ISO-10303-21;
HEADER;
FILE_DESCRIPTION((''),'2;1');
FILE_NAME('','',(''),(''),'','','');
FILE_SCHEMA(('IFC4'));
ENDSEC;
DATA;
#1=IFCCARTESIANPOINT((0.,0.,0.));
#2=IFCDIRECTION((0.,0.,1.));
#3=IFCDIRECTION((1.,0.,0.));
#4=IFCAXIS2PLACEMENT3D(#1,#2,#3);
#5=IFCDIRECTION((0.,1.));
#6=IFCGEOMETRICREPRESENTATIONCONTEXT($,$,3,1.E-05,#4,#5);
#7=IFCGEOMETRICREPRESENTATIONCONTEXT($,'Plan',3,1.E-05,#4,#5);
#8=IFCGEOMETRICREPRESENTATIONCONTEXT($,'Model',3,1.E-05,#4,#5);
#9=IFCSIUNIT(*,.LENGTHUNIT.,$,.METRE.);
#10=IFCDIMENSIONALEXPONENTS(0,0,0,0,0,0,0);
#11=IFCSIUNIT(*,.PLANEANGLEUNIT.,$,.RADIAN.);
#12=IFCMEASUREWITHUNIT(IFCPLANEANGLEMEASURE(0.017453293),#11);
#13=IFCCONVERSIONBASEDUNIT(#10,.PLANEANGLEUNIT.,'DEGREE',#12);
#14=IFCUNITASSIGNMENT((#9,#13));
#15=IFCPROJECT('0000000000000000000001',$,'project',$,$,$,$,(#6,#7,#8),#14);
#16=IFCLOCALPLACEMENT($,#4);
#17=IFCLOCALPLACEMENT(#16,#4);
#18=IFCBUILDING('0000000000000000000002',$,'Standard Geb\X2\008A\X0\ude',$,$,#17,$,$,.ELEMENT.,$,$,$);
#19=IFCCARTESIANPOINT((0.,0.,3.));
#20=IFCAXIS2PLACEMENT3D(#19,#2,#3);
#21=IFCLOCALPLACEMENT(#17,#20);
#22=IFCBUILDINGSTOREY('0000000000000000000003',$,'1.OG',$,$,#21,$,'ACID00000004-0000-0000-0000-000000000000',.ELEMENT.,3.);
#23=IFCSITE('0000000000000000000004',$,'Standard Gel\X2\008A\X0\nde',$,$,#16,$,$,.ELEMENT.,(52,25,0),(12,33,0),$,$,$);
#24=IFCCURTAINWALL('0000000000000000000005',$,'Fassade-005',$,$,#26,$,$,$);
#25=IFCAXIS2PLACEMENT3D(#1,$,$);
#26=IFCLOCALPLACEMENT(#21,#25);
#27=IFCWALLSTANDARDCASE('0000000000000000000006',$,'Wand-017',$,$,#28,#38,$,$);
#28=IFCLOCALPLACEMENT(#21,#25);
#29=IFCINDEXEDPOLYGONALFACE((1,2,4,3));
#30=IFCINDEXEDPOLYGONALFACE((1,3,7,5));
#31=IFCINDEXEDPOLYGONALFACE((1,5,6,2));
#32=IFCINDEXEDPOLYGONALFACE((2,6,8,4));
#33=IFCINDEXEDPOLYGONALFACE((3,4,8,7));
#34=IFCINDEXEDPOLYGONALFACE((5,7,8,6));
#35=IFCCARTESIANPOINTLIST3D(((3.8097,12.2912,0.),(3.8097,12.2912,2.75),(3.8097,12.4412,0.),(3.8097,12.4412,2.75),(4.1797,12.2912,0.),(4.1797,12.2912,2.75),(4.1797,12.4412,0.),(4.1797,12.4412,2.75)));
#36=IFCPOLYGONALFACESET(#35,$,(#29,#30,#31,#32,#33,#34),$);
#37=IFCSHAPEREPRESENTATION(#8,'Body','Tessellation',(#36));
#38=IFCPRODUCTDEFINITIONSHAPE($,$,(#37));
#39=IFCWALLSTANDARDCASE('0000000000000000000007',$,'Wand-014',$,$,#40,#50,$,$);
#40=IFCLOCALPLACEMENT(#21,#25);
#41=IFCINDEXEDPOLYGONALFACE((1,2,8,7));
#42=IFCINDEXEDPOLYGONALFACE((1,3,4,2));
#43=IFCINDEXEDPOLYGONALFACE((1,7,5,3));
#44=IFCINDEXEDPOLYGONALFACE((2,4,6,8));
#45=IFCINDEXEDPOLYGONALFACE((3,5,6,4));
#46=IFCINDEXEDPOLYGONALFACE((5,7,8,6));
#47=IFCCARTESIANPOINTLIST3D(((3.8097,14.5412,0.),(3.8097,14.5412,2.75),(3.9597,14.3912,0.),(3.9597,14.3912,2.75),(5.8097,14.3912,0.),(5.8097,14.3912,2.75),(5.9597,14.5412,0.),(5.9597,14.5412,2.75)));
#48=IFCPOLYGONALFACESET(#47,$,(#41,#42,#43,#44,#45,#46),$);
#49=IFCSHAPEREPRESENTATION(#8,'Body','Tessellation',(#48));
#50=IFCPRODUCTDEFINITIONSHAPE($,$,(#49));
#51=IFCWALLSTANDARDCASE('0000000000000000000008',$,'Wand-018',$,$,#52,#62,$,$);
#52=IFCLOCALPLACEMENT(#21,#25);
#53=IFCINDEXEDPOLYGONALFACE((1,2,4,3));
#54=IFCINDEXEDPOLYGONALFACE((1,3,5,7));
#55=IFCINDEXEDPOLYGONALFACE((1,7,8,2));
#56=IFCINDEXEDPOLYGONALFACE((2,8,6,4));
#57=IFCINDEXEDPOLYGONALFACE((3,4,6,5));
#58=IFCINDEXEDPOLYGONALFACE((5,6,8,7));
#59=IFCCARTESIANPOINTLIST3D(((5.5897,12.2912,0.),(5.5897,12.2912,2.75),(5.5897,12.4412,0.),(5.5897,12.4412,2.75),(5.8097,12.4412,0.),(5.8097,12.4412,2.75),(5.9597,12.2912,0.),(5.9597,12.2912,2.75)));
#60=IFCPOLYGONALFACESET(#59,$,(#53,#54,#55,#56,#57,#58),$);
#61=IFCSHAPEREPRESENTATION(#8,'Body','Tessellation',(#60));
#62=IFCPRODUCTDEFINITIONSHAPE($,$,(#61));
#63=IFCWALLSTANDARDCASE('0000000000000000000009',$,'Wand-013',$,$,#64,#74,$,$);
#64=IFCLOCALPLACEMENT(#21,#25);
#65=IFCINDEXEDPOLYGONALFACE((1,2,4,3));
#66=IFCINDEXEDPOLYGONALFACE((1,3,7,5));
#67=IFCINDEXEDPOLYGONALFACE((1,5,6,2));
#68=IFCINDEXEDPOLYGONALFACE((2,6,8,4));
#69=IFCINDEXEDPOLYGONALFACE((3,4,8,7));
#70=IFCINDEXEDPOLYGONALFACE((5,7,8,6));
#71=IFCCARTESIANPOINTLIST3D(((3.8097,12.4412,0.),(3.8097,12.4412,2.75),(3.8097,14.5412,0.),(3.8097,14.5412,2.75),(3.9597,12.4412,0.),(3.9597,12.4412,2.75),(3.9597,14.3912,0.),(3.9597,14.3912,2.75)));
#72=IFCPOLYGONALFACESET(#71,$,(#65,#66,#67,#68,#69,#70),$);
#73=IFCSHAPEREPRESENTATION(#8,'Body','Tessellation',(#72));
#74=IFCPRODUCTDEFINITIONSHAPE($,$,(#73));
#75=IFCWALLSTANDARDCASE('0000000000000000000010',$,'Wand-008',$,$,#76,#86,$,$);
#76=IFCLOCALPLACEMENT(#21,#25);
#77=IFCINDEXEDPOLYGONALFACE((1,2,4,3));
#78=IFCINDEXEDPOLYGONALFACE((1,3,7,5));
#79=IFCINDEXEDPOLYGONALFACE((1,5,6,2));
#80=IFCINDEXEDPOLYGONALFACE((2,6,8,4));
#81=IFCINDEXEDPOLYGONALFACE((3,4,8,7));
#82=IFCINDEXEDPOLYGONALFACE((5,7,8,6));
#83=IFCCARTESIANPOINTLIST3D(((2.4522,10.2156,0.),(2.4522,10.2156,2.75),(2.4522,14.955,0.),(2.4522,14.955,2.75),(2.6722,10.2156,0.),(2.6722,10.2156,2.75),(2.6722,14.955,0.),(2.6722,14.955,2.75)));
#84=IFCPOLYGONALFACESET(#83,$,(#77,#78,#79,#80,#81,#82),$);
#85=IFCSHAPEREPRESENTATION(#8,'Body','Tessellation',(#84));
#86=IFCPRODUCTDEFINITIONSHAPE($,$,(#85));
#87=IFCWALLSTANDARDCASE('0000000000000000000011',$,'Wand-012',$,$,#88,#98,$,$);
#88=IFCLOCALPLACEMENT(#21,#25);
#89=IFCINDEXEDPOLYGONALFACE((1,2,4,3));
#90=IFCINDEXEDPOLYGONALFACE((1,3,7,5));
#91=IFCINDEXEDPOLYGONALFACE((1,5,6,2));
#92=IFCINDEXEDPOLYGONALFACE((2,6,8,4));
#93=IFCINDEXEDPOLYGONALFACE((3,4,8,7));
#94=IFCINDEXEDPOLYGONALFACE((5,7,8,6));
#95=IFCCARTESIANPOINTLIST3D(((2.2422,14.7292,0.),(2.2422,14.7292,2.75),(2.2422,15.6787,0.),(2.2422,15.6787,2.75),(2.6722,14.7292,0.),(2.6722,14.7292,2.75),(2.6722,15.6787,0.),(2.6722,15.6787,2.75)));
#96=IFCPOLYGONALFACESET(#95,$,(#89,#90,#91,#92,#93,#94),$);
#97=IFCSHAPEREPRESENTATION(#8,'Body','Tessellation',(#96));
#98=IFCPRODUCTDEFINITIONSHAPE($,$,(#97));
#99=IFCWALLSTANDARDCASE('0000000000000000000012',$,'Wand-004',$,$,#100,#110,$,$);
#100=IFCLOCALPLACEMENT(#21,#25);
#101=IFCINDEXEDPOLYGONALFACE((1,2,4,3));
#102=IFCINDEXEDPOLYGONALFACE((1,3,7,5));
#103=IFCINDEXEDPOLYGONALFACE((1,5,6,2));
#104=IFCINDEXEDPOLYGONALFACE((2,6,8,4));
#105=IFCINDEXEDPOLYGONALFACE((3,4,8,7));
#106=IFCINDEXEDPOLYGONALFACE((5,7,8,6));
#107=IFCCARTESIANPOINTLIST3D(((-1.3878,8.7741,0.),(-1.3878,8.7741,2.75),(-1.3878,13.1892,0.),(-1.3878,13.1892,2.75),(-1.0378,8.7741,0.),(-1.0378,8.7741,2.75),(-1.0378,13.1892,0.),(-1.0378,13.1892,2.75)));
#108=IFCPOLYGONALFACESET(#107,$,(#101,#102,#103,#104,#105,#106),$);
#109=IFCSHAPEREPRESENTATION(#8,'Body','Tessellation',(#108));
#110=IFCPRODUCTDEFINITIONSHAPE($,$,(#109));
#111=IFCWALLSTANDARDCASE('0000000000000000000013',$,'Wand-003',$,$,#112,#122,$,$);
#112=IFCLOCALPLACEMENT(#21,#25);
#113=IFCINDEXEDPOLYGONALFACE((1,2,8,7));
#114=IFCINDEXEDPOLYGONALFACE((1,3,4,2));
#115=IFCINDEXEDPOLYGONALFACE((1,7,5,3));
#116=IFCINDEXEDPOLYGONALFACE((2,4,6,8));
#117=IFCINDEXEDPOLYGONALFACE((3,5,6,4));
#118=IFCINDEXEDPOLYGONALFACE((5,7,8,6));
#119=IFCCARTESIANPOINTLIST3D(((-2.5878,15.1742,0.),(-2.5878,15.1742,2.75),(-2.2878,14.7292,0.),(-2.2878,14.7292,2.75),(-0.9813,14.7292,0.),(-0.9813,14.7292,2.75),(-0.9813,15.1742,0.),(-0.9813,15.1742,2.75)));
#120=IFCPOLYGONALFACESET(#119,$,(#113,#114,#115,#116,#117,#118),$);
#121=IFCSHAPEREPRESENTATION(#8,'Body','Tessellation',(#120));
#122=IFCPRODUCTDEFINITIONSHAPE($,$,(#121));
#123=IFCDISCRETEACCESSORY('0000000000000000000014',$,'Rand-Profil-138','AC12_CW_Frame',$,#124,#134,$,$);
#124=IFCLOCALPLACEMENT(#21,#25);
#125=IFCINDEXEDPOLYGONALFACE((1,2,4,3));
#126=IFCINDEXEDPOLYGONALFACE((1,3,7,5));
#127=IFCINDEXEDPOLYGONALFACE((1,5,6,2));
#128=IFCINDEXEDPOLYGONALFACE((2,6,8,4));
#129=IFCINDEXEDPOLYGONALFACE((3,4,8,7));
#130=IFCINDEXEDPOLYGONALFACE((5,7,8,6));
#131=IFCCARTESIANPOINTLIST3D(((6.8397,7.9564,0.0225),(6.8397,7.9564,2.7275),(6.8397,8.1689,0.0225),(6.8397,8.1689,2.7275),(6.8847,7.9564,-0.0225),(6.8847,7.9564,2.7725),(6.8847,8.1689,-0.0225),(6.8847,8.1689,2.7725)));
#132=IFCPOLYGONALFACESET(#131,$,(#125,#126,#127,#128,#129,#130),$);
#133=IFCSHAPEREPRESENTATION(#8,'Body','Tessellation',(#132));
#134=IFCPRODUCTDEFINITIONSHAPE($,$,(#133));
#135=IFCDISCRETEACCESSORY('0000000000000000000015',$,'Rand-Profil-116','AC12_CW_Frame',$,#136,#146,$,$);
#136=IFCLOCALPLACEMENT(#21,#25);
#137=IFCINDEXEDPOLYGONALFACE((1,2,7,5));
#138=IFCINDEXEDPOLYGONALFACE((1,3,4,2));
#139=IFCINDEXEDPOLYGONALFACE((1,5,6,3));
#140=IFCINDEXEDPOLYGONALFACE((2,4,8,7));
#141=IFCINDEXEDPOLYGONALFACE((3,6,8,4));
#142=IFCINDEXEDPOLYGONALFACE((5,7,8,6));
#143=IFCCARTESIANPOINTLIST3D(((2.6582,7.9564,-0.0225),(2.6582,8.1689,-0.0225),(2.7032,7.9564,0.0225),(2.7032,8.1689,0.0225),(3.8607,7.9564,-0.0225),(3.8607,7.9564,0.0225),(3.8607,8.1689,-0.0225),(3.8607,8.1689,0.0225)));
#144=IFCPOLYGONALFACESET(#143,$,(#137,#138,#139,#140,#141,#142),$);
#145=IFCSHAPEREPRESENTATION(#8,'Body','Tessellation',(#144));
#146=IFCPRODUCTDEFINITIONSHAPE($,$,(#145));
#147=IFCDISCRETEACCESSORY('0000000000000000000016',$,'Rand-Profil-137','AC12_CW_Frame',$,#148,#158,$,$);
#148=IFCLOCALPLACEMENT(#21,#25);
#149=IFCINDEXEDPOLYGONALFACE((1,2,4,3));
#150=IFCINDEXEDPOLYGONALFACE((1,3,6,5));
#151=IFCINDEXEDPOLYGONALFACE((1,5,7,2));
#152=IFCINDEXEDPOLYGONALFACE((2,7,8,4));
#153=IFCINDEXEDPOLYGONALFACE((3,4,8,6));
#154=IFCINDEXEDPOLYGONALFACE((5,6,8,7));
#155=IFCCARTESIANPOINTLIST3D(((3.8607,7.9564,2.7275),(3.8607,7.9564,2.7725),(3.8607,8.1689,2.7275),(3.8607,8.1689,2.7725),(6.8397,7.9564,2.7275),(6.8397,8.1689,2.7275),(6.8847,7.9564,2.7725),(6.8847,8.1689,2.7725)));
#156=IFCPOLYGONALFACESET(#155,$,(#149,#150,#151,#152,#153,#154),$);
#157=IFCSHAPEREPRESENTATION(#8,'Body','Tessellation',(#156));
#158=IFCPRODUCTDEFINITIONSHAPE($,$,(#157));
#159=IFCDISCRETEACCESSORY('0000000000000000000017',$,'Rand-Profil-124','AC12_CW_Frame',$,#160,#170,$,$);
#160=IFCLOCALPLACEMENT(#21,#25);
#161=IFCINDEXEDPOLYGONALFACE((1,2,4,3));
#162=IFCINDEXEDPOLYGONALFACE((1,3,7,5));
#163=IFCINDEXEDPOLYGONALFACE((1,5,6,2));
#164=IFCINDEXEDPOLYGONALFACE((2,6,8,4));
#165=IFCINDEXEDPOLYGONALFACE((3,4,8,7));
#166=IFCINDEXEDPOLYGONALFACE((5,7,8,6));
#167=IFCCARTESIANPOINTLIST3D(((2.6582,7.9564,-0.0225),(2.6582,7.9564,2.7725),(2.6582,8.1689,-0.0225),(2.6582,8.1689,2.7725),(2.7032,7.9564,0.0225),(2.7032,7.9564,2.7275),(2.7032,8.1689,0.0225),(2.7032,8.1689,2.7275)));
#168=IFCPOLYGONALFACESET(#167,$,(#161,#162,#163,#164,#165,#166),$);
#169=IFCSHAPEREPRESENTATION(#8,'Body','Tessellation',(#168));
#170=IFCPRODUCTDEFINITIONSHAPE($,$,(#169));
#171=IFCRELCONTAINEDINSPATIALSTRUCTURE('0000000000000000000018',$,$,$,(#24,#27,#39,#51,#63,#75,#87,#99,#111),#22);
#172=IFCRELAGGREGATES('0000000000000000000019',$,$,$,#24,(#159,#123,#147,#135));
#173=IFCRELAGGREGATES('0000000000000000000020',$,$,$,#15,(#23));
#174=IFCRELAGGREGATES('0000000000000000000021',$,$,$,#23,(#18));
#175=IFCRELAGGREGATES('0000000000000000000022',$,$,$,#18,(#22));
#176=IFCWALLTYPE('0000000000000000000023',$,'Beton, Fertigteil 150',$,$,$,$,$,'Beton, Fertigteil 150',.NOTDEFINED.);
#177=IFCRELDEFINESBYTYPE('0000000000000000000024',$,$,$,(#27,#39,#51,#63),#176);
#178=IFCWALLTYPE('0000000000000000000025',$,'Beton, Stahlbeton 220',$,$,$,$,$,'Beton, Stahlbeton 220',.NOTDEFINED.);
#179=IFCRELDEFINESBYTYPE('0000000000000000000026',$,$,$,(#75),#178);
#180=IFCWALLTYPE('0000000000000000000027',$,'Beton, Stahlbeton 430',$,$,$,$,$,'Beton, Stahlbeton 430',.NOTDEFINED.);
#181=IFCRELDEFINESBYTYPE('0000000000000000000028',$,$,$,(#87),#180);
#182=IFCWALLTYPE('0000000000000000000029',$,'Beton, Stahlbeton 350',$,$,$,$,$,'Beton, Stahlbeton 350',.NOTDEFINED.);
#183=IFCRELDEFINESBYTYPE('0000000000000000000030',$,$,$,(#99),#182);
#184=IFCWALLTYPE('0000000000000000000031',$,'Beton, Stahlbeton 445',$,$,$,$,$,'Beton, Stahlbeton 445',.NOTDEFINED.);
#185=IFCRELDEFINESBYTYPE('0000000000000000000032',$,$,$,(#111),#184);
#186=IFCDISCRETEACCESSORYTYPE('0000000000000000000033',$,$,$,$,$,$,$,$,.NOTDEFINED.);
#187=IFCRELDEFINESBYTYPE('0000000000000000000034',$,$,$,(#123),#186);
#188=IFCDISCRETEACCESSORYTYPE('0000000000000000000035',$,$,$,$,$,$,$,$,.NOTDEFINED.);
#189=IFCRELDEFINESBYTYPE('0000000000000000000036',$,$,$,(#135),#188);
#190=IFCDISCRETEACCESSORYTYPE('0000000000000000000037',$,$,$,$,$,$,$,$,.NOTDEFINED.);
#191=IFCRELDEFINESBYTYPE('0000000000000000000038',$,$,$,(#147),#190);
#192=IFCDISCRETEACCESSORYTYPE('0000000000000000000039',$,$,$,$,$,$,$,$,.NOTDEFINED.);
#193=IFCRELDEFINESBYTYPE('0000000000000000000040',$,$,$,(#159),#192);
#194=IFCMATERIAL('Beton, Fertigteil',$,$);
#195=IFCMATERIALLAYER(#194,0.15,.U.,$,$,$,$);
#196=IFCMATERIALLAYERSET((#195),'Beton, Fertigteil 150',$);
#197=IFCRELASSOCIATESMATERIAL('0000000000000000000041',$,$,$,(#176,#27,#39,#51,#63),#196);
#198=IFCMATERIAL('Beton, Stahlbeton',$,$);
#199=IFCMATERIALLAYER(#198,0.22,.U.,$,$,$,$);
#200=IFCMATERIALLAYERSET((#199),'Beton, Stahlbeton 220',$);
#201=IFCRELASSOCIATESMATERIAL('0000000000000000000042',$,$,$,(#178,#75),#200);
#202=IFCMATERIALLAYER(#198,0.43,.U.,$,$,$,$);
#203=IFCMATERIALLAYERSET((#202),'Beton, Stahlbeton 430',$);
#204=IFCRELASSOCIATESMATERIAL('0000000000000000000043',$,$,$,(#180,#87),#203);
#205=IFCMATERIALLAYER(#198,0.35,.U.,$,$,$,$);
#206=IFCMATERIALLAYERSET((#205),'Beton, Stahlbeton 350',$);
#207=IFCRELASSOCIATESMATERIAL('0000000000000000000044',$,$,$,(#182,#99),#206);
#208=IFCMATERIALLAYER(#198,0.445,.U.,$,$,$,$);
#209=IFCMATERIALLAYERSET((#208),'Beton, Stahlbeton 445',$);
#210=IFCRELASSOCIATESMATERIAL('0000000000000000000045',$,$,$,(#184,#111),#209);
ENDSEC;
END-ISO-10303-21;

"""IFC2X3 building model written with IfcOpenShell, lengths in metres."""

from ifc_helpers import new_model, entity, si_unit, converted_unit, direction, frame, origin_with_axes, place, context, project, spatial, polyline, outline, extrude, source, transform, mapped, material, layer, layer_set, layer_usage, type_object, type_shapes, element, aggregate, save


model = new_model("IFC2X3")

# Units and contexts
model_context = context("Model", 3, precision=1e-05, world=origin_with_axes(), true_north=direction((0.0, 1.0)))
plan_context = context("Plan", 3, precision=1e-05, world=origin_with_axes(), true_north=direction((0.0, 1.0)))
context_of_model = context(None, 3, precision=1e-05, world=origin_with_axes(), true_north=direction((0.0, 1.0)))
ifc_project = project(units=[si_unit("LENGTHUNIT", "METRE"), converted_unit("PLANEANGLEUNIT", "DEGREE", entity("IfcPlaneAngleMeasure", 0.017453293), si_unit("PLANEANGLEUNIT", "RADIAN"), dimensions=[0, 0, 0, 0, 0, 0, 0])], contexts=[context_of_model, plan_context, model_context])

# Site, building, storey
site_placement = place(None, origin_with_axes())
site = spatial("IfcSite", under=ifc_project, at=site_placement, Name="Standard Gel\u008ande", CompositionType="ELEMENT", RefLatitude=(52, 25, 0), RefLongitude=(12, 33, 0))
building_placement = place(site_placement, origin_with_axes())
building = spatial("IfcBuilding", under=site, at=building_placement, Name="Standard Geb\u008aude", CompositionType="ELEMENT")
storey_placement = place(building_placement, frame((0.0, 0.0, 3.0), z_axis=(0.0, 0.0, 1.0), x_axis=(1.0, 0.0, 0.0)))
storey = spatial("IfcBuildingStorey", under=building, at=storey_placement, Name="1.OG", LongName="ACID00000004-0000-0000-0000-000000000000", CompositionType="ELEMENT", Elevation=3.0)

# Curtain wall
curtain_wall_placement = place(storey_placement, frame((2.6807, 7.9914, 0.0), z_axis=(0.0, 0.0, 1.0), x_axis=(1.0, 0.0, 0.0)))
curtain_wall = element("IfcCurtainWall", 1, at=curtain_wall_placement, inside=storey, Name="Fassade-005")

# Shared definitions
ifc_material_1 = material(Name="Beton, Stahlbeton")

# Walls
ifc_material_2 = material(Name="Beton, Fertigteil")
ifc_layer_1 = layer(ifc_material_2, 0.15, ventilated="UNKNOWN")
ifc_layer_set_1 = layer_set([ifc_layer_1], Name="Beton, Fertigteil 150")
wall_type_1 = type_object("IfcWallType", Name="Beton, Fertigteil 150", ElementType="Beton, Fertigteil 150", PredefinedType="NOTDEFINED", material=ifc_layer_set_1)
ifc_layer_usage_1 = layer_usage(ifc_layer_set_1, "AXIS2", "POSITIVE", 0.0)
wall_1_placement = place(storey_placement, frame((3.8097, 12.2912, 0.0), z_axis=(0.0, 0.0, 1.0), x_axis=(1.0, 0.0, 0.0)))
element("IfcWallStandardCase", 2, at=wall_1_placement, inside=storey, type_object=wall_type_1, material=ifc_layer_usage_1, Name="Wand-017", context=model_context, shape_type="SweptSolid", body=[
    extrude(outline(polyline([(0.0, 0.0), (0.37, 0.0), (0.37, 0.15), (0.0, 0.15), (0.0, 0.0)])), origin_with_axes(), (0.0, 0.0, 1.0), 2.75),
])
ifc_layer_usage_2 = layer_usage(ifc_layer_set_1, "AXIS2", "NEGATIVE", 0.0)
wall_2_placement = place(storey_placement, frame((3.9597, 14.5412, 0.0), z_axis=(0.0, 0.0, 1.0), x_axis=(1.0, 0.0, 0.0)))
element("IfcWallStandardCase", 3, at=wall_2_placement, inside=storey, type_object=wall_type_1, material=ifc_layer_usage_2, Name="Wand-014", context=model_context, shape_type="SweptSolid", body=[
    extrude(outline(polyline([(0.0, -0.15), (1.85, -0.15), (2.0, 0.0), (-0.15, 0.0), (0.0, -0.15)])), origin_with_axes(), (0.0, 0.0, 1.0), 2.75),
])
ifc_layer_usage_3 = layer_usage(ifc_layer_set_1, "AXIS2", "NEGATIVE", 0.0)
wall_3_placement = place(storey_placement, frame((5.9597, 12.2912, 0.0), z_axis=(0.0, 0.0, 1.0), x_axis=(-1.0, 0.0, 0.0)))
element("IfcWallStandardCase", 4, at=wall_3_placement, inside=storey, type_object=wall_type_1, material=ifc_layer_usage_3, Name="Wand-018", context=model_context, shape_type="SweptSolid", body=[
    extrude(outline(polyline([(0.15, -0.15), (0.37, -0.15), (0.37, 0.0), (0.0, 0.0), (0.15, -0.15)])), origin_with_axes(), (0.0, 0.0, 1.0), 2.75),
])
ifc_layer_usage_4 = layer_usage(ifc_layer_set_1, "AXIS2", "NEGATIVE", 0.0)
wall_4_placement = place(storey_placement, frame((3.9597, 14.5412, 0.0), z_axis=(0.0, 0.0, 1.0), x_axis=(0.0, -1.0, 0.0)))
element("IfcWallStandardCase", 5, at=wall_4_placement, inside=storey, type_object=wall_type_1, material=ifc_layer_usage_4, Name="Wand-013", context=model_context, shape_type="SweptSolid", body=[
    extrude(outline(polyline([(0.0, -0.15), (2.1, -0.15), (2.1, 0.0), (0.15, 0.0), (0.0, -0.15)])), origin_with_axes(), (0.0, 0.0, 1.0), 2.75),
])
ifc_layer_2 = layer(ifc_material_1, 0.22, ventilated="UNKNOWN")
ifc_layer_set_2 = layer_set([ifc_layer_2], Name="Beton, Stahlbeton 220")
ifc_layer_usage_5 = layer_usage(ifc_layer_set_2, "AXIS2", "NEGATIVE", 0.0)
wall_type_2 = type_object("IfcWallType", Name="Beton, Stahlbeton 220", ElementType="Beton, Stahlbeton 220", PredefinedType="NOTDEFINED", material=ifc_layer_set_2)
wall_5_placement = place(storey_placement, frame((2.6722, 14.955, 0.0), z_axis=(0.0, 0.0, 1.0), x_axis=(0.0, -1.0, 0.0)))
element("IfcWallStandardCase", 6, at=wall_5_placement, inside=storey, type_object=wall_type_2, material=ifc_layer_usage_5, Name="Wand-008", context=model_context, shape_type="SweptSolid", body=[
    extrude(outline(polyline([(0.0, -0.22), (4.7394, -0.22), (4.7394, 0.0), (0.0, 0.0), (0.0, -0.22)])), origin_with_axes(), (0.0, 0.0, 1.0), 2.75),
])
ifc_layer_3 = layer(ifc_material_1, 0.43, ventilated="UNKNOWN")
ifc_layer_set_3 = layer_set([ifc_layer_3], Name="Beton, Stahlbeton 430")
ifc_layer_usage_6 = layer_usage(ifc_layer_set_3, "AXIS2", "POSITIVE", 0.0)
wall_type_3 = type_object("IfcWallType", Name="Beton, Stahlbeton 430", ElementType="Beton, Stahlbeton 430", PredefinedType="NOTDEFINED", material=ifc_layer_set_3)
wall_6_placement = place(storey_placement, frame((2.6722, 14.7292, 0.0), z_axis=(0.0, 0.0, 1.0), x_axis=(0.0, 1.0, 0.0)))
element("IfcWallStandardCase", 7, at=wall_6_placement, inside=storey, type_object=wall_type_3, material=ifc_layer_usage_6, Name="Wand-012", context=model_context, shape_type="SweptSolid", body=[
    extrude(outline(polyline([(0.0, 0.0), (0.9495, 0.0), (0.9495, 0.43), (0.0, 0.43), (0.0, 0.0)])), origin_with_axes(), (0.0, 0.0, 1.0), 2.75),
])
ifc_layer_4 = layer(ifc_material_1, 0.35, ventilated="UNKNOWN")
ifc_layer_set_4 = layer_set([ifc_layer_4], Name="Beton, Stahlbeton 350")
ifc_layer_usage_7 = layer_usage(ifc_layer_set_4, "AXIS2", "NEGATIVE", 0.0)
wall_type_4 = type_object("IfcWallType", Name="Beton, Stahlbeton 350", ElementType="Beton, Stahlbeton 350", PredefinedType="NOTDEFINED", material=ifc_layer_set_4)
wall_7_placement = place(storey_placement, frame((-1.3878, 8.7741, 0.0), z_axis=(0.0, 0.0, 1.0), x_axis=(0.0, 1.0, 0.0)))
element("IfcWallStandardCase", 8, at=wall_7_placement, inside=storey, type_object=wall_type_4, material=ifc_layer_usage_7, Name="Wand-004", context=model_context, shape_type="SweptSolid", body=[
    extrude(outline(polyline([(0.0, -0.35), (4.4151, -0.35), (4.4151, 0.0), (0.0, 0.0), (0.0, -0.35)])), origin_with_axes(), (0.0, 0.0, 1.0), 2.75),
])
ifc_layer_5 = layer(ifc_material_1, 0.445, ventilated="UNKNOWN")
ifc_layer_set_5 = layer_set([ifc_layer_5], Name="Beton, Stahlbeton 445")
ifc_layer_usage_8 = layer_usage(ifc_layer_set_5, "AXIS2", "NEGATIVE", 0.0)
wall_type_5 = type_object("IfcWallType", Name="Beton, Stahlbeton 445", ElementType="Beton, Stahlbeton 445", PredefinedType="NOTDEFINED", material=ifc_layer_set_5)
wall_8_placement = place(storey_placement, frame((-2.5878, 15.1742, 0.0), z_axis=(0.0, 0.0, 1.0), x_axis=(1.0, 0.0, 0.0)))
element("IfcWallStandardCase", 9, at=wall_8_placement, inside=storey, type_object=wall_type_5, material=ifc_layer_usage_8, Name="Wand-003", context=model_context, shape_type="SweptSolid", body=[
    extrude(outline(polyline([(0.3, -0.445), (1.6065, -0.445), (1.6065, 0.0), (0.0, 0.0), (0.3, -0.445)])), origin_with_axes(), (0.0, 0.0, 1.0), 2.75),
])

# Discrete accessories
discrete_accessory_type_1 = type_object("IfcDiscreteAccessoryType")
shared_shape_1 = source(origin_with_axes(), model_context, "Body", "SweptSolid", [
    extrude(outline(polyline([(0.0, 0.0), (0.0636, 0.0), (-1.9127, -1.9764), (-1.9127, -1.9127), (0.0, 0.0)])), origin_with_axes(), (0.0, 0.0, 1.0), 0.2125),
])
type_shapes(discrete_accessory_type_1, [shared_shape_1])
discrete_accessory_1_placement = place(storey_placement, frame((6.8397, 7.9564, 0.0225), z_axis=(0.0, 1.0, 0.0), x_axis=(0.707107, 0.0, -0.707107)))
discrete_accessory_1 = element("IfcDiscreteAccessory", 10, at=discrete_accessory_1_placement, type_object=discrete_accessory_type_1, Name="Rand-Profil-138", Description="AC12_CW_Frame", context=model_context, shape_type="MappedRepresentation", body=[
    mapped(shared_shape_1, transform((0.0, 0.0, 0.0), scale=1.0)),
])
discrete_accessory_type_2 = type_object("IfcDiscreteAccessoryType")
shared_shape_2 = source(origin_with_axes(), model_context, "Body", "SweptSolid", [
    extrude(outline(polyline([(0.0, 0.0), (0.0636, 0.0), (-0.7867, -0.8503), (-0.8185, -0.8185), (0.0, 0.0)])), origin_with_axes(), (0.0, 0.0, 1.0), 0.2125),
])
type_shapes(discrete_accessory_type_2, [shared_shape_2])
discrete_accessory_2_placement = place(storey_placement, frame((2.7032, 7.9564, 0.0225), z_axis=(0.0, 1.0, 0.0), x_axis=(-0.707107, 0.0, -0.707107)))
discrete_accessory_2 = element("IfcDiscreteAccessory", 11, at=discrete_accessory_2_placement, type_object=discrete_accessory_type_2, Name="Rand-Profil-116", Description="AC12_CW_Frame", context=model_context, shape_type="MappedRepresentation", body=[
    mapped(shared_shape_2, transform((0.0, 0.0, 0.0), scale=1.0)),
])
discrete_accessory_type_3 = type_object("IfcDiscreteAccessoryType")
shared_shape_3 = source(origin_with_axes(), model_context, "Body", "SweptSolid", [
    extrude(outline(polyline([(0.0, 0.0), (0.0636, 0.0), (-2.0746, -2.1383), (-2.1064, -2.1064), (0.0, 0.0)])), origin_with_axes(), (0.0, 0.0, 1.0), 0.2125),
])
type_shapes(discrete_accessory_type_3, [shared_shape_3])
discrete_accessory_3_placement = place(storey_placement, frame((6.8397, 7.9564, 2.7275), z_axis=(0.0, 1.0, 0.0), x_axis=(0.707107, 0.0, 0.707107)))
discrete_accessory_3 = element("IfcDiscreteAccessory", 12, at=discrete_accessory_3_placement, type_object=discrete_accessory_type_3, Name="Rand-Profil-137", Description="AC12_CW_Frame", context=model_context, shape_type="MappedRepresentation", body=[
    mapped(shared_shape_3, transform((0.0, 0.0, 0.0), scale=1.0)),
])
discrete_accessory_type_4 = type_object("IfcDiscreteAccessoryType")
shared_shape_4 = source(origin_with_axes(), model_context, "Body", "SweptSolid", [
    extrude(outline(polyline([(0.0, 0.0), (0.0636, 0.0), (1.9764, -1.9127), (1.9764, -1.9764), (0.0, 0.0)])), origin_with_axes(), (0.0, 0.0, 1.0), 0.2125),
])
type_shapes(discrete_accessory_type_4, [shared_shape_4])
discrete_accessory_4_placement = place(storey_placement, frame((2.6582, 7.9564, -0.0225), z_axis=(0.0, 1.0, 0.0), x_axis=(0.707107, 0.0, 0.707107)))
discrete_accessory_4 = element("IfcDiscreteAccessory", 13, at=discrete_accessory_4_placement, type_object=discrete_accessory_type_4, Name="Rand-Profil-124", Description="AC12_CW_Frame", context=model_context, shape_type="MappedRepresentation", body=[
    mapped(shared_shape_4, transform((0.0, 0.0, 0.0), scale=1.0)),
])
aggregate(curtain_wall, [discrete_accessory_4, discrete_accessory_1, discrete_accessory_3, discrete_accessory_2])

save(model, "model.ifc")
